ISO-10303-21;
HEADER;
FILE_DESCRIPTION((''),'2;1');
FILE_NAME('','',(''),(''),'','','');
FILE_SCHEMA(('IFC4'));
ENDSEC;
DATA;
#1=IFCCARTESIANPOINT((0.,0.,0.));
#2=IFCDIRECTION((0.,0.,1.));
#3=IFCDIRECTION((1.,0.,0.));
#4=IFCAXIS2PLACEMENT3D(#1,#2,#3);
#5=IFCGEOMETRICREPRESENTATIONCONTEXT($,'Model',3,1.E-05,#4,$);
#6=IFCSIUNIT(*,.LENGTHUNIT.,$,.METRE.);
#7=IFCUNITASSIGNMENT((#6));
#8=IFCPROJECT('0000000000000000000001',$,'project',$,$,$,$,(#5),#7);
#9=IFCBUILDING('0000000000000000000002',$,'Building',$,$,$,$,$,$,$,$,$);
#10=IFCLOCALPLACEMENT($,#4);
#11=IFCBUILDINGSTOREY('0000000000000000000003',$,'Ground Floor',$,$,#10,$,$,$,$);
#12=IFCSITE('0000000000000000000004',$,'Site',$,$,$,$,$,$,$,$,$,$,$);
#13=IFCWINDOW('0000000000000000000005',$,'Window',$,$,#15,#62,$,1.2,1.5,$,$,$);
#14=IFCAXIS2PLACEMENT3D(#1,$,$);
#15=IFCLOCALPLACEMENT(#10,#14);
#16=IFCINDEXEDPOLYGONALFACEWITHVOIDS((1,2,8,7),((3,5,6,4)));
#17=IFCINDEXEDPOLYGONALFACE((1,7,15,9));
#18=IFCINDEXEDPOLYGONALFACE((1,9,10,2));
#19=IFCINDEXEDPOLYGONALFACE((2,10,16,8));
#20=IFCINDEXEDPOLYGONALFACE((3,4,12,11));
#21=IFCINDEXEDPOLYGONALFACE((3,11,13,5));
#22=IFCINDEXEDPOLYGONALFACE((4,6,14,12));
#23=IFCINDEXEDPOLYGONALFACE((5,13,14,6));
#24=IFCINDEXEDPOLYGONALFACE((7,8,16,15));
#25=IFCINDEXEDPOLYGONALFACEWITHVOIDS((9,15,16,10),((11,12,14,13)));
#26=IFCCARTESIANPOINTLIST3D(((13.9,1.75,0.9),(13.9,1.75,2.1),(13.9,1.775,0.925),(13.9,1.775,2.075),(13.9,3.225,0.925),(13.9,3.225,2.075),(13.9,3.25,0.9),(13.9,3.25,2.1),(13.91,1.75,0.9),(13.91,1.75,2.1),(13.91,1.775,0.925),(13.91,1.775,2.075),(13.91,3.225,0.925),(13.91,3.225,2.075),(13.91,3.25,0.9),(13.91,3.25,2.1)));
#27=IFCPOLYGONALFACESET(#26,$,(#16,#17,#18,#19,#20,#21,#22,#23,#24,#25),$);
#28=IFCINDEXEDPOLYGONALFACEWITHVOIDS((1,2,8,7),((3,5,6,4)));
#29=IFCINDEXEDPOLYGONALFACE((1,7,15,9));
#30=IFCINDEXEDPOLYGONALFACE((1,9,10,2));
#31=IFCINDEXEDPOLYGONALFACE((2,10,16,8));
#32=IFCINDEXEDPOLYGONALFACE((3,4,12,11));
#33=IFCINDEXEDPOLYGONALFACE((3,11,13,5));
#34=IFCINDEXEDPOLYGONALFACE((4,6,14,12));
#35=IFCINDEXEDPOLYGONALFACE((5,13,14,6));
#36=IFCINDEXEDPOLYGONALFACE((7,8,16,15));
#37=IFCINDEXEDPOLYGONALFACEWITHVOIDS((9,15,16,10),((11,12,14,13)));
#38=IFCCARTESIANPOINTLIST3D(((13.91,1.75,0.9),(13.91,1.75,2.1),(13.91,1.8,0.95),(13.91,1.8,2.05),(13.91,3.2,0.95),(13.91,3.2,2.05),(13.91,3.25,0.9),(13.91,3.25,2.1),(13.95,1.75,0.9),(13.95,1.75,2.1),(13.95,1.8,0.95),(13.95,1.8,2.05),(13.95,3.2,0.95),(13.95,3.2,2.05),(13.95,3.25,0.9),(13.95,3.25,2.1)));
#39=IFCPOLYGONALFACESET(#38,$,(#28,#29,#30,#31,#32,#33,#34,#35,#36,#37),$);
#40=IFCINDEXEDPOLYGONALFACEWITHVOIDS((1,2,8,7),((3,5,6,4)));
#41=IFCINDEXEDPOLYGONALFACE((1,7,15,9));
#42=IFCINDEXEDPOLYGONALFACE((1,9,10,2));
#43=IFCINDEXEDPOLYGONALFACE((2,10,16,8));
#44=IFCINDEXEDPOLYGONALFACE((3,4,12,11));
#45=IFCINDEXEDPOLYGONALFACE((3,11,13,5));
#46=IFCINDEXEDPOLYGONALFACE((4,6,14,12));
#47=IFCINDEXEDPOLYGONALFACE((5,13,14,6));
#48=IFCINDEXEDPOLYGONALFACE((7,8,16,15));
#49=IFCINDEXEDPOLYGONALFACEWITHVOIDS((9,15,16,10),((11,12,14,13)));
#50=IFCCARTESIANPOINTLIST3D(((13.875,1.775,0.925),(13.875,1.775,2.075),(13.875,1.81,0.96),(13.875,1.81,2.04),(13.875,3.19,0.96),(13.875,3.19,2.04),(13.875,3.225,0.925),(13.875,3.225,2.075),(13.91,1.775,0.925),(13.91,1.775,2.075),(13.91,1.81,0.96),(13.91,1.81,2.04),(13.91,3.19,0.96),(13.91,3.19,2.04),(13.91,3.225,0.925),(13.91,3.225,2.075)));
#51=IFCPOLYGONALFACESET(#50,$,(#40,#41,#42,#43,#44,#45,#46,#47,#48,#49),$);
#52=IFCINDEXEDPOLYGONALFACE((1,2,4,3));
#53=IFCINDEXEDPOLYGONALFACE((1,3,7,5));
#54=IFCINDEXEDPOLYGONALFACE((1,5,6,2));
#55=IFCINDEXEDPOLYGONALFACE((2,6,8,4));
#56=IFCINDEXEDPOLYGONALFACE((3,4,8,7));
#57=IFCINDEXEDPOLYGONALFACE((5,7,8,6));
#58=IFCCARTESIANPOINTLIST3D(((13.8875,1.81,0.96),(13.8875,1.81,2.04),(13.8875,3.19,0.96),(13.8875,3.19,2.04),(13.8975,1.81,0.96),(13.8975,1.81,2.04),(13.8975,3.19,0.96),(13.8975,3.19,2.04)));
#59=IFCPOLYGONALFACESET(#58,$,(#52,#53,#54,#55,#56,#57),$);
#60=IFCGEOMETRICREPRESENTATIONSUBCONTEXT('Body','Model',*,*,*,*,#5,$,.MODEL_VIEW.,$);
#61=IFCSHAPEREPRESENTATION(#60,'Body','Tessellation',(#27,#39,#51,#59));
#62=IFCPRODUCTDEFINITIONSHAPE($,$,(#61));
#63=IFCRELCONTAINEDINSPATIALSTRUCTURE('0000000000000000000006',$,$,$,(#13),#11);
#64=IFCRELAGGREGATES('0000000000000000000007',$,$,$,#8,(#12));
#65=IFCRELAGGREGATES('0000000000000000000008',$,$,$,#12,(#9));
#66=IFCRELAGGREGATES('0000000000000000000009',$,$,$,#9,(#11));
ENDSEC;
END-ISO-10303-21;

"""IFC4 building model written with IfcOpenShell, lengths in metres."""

from ifc_helpers import new_model, si_unit, frame, origin_with_axes, place, context, subcontext, project, spatial, line, indexed_curve, outline, extrude, element, save


model = new_model("IFC4")

# Units and contexts
model_context = context("Model", 3, precision=1e-05, world=origin_with_axes())
body_context = subcontext(model_context, "Body", "Model", "MODEL_VIEW")
ifc_project = project(units=[si_unit("LENGTHUNIT", "METRE")], contexts=[model_context])

# Site, building, storey
site = spatial("IfcSite", under=ifc_project, Name="Site")
building = spatial("IfcBuilding", under=site, Name="Building")
storey_placement = place(None, origin_with_axes())
storey = spatial("IfcBuildingStorey", under=building, at=storey_placement, Name="Ground Floor")

# Window
for number, where, z_axis, x_axis, name in (
    (1, (14.0, 1.75, 0.9), (0.0, 0.0, 1.0), (0.0, 1.0, 0.0), "Window"),
):
    element("IfcWindow", number, at=place(storey_placement, frame(where, z_axis=z_axis, x_axis=x_axis)), inside=storey, Name=name, OverallHeight=1.2, OverallWidth=1.5, context=body_context, shape_type="SweptSolid", body=[
        extrude(outline(indexed_curve([(0.0, 0.0), (1.5, 0.0), (1.5, 1.2), (0.0, 1.2)], segments=[line(1, 2, 3, 4, 1)]), holes=[indexed_curve([(0.025, 0.025), (1.475, 0.025), (1.475, 1.175), (0.025, 1.175)], segments=[line(1, 2, 3, 4, 1)])]), frame((0.0, 0.09, 0.0), z_axis=(0.0, -1.0, 0.0), x_axis=(1.0, 0.0, 0.0)), (0.0, 0.0, -1.0), 0.01),
        extrude(outline(indexed_curve([(0.0, 0.0), (1.5, 0.0), (1.5, 1.2), (0.0, 1.2)], segments=[line(1, 2, 3, 4, 1)]), holes=[indexed_curve([(0.05, 0.05), (1.45, 0.05), (1.45, 1.15), (0.05, 1.15)], segments=[line(1, 2, 3, 4, 1)])]), frame((0.0, 0.05, 0.0), z_axis=(0.0, -1.0, 0.0), x_axis=(1.0, 0.0, 0.0)), (0.0, 0.0, -1.0), 0.04),
        extrude(outline(indexed_curve([(0.0, 0.0), (1.45, 0.0), (1.45, 1.15), (0.0, 1.15)], segments=[line(1, 2, 3, 4, 1)]), holes=[indexed_curve([(0.035, 0.035), (1.415, 0.035), (1.415, 1.115), (0.035, 1.115)], segments=[line(1, 2, 3, 4, 1)])]), frame((0.025, 0.09, 0.025), z_axis=(0.0, -1.0, 0.0), x_axis=(1.0, 0.0, 0.0)), (0.0, 0.0, -1.0), 0.035),
        extrude(outline(indexed_curve([(0.035, 0.035), (1.415, 0.035), (1.415, 1.115), (0.035, 1.115)], segments=[line(1, 2, 3, 4, 1)])), frame((0.025, 0.1025, 0.025), z_axis=(0.0, -1.0, 0.0), x_axis=(1.0, 0.0, 0.0)), (0.0, 0.0, -1.0), 0.01),
    ])

save(model, "model.ifc")
